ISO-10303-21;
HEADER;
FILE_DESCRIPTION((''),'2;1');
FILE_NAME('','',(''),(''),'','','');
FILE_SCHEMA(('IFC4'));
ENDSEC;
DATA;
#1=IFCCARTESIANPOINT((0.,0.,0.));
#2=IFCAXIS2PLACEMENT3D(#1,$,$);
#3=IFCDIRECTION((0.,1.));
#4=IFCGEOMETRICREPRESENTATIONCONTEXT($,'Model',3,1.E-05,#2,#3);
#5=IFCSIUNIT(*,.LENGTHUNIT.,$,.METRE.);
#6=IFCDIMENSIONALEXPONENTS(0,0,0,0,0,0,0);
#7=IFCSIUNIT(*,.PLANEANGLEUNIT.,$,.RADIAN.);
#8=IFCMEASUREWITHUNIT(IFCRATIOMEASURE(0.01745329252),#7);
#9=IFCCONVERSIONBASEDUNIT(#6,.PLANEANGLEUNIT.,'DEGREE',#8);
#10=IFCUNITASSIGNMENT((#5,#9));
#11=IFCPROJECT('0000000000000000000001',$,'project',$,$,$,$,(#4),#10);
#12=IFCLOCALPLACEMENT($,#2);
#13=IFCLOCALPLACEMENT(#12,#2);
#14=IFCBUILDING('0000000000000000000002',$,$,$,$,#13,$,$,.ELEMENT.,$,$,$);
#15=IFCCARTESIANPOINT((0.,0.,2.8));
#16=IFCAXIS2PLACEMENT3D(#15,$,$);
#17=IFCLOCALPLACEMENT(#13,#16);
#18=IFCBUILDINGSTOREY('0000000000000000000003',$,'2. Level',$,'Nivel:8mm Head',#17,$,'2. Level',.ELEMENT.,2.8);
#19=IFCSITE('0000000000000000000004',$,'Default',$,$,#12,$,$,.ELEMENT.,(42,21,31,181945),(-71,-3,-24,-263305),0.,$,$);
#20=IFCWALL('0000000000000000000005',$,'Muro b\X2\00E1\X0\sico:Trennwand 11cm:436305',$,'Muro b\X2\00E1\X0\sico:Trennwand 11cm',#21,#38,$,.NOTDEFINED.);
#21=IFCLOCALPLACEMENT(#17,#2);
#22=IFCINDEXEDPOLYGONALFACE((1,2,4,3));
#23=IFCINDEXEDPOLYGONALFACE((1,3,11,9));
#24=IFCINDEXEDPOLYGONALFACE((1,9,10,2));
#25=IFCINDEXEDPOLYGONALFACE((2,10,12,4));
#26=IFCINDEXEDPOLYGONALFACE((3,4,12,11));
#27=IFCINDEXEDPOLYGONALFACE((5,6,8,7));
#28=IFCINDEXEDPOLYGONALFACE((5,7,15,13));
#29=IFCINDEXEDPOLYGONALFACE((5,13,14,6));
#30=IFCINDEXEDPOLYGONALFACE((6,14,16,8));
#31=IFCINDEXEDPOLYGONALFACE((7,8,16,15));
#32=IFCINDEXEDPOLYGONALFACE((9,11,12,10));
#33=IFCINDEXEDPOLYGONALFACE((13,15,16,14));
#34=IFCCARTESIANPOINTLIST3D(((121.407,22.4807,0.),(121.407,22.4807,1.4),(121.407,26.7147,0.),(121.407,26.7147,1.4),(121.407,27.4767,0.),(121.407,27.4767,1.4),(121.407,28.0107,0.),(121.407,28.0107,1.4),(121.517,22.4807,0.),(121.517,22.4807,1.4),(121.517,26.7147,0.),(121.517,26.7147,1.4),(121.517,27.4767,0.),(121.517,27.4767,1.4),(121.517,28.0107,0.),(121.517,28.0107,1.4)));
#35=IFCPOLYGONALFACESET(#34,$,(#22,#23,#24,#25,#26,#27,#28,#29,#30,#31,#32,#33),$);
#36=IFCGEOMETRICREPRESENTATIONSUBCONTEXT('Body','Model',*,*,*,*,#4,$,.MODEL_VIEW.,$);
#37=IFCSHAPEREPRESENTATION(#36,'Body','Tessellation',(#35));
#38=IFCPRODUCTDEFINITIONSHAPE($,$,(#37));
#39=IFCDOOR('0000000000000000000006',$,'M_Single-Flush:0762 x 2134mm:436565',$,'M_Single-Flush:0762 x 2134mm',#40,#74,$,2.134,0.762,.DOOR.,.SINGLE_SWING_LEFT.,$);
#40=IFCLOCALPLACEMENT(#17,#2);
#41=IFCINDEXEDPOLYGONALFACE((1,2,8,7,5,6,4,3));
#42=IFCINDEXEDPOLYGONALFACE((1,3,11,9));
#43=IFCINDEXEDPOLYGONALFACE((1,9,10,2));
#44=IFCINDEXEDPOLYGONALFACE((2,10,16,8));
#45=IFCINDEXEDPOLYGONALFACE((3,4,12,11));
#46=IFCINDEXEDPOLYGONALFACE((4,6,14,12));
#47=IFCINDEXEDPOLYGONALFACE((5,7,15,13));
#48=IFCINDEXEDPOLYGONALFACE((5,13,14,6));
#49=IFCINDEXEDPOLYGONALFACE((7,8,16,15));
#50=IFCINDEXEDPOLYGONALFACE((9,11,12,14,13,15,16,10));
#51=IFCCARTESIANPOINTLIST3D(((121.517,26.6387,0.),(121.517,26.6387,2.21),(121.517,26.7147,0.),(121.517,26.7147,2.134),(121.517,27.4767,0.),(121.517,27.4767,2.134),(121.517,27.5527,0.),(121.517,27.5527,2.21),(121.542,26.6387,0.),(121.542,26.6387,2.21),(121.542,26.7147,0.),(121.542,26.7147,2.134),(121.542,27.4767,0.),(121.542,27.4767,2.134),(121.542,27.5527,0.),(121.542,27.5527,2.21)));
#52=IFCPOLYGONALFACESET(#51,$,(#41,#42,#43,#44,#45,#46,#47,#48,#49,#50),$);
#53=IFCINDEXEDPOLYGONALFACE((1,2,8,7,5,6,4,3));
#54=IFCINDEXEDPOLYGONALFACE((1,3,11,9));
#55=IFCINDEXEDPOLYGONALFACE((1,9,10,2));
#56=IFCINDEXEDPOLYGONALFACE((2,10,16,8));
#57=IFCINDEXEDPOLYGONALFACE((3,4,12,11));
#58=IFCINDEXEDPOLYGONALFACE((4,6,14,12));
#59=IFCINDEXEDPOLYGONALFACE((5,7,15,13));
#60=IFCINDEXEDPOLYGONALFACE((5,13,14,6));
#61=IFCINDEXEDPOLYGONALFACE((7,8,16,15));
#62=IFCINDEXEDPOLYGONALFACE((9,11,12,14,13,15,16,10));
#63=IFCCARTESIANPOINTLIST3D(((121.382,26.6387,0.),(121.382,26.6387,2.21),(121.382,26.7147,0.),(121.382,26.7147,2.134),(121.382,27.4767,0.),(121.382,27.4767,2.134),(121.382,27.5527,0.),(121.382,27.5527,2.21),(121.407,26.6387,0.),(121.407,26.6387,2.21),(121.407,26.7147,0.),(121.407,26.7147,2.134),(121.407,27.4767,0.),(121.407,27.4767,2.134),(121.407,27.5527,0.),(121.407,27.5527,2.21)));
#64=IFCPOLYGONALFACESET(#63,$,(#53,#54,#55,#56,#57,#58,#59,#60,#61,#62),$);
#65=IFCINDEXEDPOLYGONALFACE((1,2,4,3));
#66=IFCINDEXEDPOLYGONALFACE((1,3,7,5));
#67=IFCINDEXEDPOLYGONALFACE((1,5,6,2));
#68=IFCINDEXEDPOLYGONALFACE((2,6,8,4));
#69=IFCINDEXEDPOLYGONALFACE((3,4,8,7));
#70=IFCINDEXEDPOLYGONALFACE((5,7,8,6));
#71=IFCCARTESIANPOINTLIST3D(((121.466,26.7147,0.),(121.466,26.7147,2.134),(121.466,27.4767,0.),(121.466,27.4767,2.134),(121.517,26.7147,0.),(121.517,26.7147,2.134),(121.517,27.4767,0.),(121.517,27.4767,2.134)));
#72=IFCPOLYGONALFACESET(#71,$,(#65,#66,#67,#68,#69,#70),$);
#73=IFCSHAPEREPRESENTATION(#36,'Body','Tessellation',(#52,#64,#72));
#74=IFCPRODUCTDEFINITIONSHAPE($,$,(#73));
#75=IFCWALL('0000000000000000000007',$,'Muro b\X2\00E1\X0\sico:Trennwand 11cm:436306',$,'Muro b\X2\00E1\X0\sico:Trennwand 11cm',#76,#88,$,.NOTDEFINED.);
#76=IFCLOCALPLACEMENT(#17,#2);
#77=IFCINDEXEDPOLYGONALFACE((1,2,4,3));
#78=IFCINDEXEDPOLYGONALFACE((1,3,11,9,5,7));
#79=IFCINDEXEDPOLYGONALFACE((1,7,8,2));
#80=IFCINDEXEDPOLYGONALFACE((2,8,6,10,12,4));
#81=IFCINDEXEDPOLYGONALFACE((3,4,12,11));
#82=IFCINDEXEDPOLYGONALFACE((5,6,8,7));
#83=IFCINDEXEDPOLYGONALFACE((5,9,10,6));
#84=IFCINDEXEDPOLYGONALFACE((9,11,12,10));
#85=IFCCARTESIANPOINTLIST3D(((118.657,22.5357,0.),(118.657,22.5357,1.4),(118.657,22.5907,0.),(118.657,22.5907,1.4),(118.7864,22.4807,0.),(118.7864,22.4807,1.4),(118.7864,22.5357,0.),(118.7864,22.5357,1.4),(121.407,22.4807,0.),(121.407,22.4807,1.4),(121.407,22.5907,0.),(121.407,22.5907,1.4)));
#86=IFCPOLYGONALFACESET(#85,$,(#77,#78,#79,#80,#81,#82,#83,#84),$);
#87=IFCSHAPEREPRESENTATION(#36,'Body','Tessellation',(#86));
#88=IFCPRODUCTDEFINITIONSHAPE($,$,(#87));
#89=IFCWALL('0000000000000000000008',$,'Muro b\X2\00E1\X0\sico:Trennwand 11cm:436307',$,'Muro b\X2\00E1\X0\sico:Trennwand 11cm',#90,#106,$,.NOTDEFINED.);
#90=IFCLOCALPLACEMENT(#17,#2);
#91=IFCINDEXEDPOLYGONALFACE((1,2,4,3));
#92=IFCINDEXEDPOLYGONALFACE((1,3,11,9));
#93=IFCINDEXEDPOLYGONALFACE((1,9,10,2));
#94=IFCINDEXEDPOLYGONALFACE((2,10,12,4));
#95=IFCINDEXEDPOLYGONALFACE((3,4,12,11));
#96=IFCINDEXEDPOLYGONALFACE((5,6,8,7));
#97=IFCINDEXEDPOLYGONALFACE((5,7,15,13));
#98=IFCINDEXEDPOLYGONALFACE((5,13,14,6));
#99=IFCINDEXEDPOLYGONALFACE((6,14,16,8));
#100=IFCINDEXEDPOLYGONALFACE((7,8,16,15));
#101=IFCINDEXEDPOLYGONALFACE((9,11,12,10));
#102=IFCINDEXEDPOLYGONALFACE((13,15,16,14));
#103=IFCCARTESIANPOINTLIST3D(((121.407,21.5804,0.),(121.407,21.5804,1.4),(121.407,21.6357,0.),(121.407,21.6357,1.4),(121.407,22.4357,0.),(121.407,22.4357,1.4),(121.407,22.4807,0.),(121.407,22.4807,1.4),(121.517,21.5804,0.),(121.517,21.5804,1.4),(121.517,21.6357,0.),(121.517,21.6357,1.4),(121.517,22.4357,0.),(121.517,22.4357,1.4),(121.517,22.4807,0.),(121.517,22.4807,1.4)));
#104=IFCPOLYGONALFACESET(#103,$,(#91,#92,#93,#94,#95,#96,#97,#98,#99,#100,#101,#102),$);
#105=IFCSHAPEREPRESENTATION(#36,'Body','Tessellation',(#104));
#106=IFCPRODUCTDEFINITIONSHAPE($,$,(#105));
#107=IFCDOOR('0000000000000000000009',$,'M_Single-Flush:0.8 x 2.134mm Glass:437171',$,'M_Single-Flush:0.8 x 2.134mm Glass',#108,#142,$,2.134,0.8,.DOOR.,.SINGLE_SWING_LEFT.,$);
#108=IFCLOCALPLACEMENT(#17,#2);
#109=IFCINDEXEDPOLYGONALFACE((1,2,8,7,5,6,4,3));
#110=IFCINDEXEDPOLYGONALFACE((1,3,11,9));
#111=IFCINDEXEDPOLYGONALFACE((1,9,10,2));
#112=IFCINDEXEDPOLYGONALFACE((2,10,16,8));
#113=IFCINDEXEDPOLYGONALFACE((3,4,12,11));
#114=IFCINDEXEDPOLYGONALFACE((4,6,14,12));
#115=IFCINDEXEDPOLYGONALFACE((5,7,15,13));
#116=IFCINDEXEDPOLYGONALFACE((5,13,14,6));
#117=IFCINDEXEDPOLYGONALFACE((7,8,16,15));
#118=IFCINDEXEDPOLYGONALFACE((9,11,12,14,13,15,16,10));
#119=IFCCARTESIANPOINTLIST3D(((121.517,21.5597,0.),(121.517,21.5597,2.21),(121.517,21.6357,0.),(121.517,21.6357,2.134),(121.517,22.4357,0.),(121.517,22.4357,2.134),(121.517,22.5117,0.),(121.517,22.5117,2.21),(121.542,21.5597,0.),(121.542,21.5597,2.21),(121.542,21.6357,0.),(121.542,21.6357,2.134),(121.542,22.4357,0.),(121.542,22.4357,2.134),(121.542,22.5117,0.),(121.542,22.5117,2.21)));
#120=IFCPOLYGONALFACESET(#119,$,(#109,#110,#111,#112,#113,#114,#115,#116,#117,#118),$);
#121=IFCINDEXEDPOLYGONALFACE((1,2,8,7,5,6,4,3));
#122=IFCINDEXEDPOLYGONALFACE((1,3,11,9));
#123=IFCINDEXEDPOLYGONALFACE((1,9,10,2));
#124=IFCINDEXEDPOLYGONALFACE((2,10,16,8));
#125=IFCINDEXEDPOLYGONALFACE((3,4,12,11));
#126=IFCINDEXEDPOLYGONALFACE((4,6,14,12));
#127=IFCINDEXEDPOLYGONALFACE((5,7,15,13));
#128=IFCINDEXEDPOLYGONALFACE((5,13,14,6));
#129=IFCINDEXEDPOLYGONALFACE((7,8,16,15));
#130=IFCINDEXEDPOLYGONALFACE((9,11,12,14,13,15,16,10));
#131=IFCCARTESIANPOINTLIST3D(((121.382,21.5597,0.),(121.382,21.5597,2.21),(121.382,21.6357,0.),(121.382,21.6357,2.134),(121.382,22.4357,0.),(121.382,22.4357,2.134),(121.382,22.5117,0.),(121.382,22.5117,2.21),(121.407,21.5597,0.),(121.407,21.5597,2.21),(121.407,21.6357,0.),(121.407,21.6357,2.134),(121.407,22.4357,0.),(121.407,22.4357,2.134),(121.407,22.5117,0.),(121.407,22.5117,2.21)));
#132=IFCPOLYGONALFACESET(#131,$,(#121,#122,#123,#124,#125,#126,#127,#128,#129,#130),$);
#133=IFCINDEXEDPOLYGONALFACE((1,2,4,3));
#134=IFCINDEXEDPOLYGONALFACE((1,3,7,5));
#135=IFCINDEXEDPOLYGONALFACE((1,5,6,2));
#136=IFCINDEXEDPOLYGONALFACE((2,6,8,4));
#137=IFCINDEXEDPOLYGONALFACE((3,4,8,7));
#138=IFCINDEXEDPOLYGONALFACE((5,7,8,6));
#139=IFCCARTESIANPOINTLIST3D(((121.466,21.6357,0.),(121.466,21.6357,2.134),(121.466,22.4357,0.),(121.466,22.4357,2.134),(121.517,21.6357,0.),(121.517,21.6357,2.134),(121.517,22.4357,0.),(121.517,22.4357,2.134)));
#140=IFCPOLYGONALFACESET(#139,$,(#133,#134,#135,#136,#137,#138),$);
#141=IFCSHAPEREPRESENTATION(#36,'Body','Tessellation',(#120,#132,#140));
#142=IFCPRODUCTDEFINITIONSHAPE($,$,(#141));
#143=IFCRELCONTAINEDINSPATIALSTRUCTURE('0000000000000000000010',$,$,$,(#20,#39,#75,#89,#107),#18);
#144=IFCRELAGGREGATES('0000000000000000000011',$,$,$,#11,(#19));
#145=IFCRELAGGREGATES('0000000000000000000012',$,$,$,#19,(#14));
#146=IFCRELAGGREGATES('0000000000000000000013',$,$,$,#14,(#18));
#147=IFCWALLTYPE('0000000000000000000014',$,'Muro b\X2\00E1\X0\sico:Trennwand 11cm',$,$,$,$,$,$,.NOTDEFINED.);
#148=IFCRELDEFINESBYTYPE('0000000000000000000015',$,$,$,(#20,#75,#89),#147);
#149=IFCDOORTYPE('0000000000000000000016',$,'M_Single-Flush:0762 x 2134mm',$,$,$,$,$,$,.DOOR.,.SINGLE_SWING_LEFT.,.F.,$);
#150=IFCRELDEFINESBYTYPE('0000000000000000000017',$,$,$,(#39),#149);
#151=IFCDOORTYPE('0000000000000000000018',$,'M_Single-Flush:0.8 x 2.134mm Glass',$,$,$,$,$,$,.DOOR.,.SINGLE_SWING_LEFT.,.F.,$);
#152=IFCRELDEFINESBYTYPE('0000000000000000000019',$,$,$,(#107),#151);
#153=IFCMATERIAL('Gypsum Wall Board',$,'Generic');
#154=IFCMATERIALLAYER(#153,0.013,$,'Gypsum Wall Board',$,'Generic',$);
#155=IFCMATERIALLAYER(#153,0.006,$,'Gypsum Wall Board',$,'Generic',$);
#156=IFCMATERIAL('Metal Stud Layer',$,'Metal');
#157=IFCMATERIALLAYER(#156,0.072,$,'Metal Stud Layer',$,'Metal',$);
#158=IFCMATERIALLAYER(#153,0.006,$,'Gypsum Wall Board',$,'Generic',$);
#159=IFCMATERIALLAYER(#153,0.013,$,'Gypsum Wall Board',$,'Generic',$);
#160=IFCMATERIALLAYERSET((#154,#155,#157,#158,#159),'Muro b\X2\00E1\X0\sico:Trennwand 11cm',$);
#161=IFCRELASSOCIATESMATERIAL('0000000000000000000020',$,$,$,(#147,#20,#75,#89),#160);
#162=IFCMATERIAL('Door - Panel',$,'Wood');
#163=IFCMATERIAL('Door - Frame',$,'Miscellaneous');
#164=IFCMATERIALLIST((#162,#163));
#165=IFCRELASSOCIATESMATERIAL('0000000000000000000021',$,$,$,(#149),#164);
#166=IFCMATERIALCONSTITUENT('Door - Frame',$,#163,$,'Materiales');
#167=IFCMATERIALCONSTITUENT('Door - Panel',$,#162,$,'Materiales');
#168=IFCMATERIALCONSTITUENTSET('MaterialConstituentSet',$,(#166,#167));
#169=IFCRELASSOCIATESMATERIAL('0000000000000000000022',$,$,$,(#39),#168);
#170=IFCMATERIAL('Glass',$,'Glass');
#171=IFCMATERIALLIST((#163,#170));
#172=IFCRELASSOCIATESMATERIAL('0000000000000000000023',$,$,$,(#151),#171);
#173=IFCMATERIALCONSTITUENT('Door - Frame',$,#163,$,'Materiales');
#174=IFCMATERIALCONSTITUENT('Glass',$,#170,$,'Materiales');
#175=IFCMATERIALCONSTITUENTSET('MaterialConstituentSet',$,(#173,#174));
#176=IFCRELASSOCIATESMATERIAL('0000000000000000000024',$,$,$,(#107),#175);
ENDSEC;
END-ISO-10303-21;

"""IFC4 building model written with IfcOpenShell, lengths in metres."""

from ifc_helpers import new_model, entity, si_unit, converted_unit, direction, frame, frame_2d, origin, origin_2d_with_axis, place, context, subcontext, project, spatial, polyline, rectangle, outline, extrude, clip, halfspace, source, transform, mapped, material, material_list, layer, layer_set, layer_usage, constituent, constituent_set, type_object, type_shapes, element, fill, save


model = new_model("IFC4")

# Units and contexts
model_context = context("Model", 3, precision=1e-05, world=origin(), true_north=direction((0.0, 1.0)))
body_context = subcontext(model_context, "Body", "Model", "MODEL_VIEW")
ifc_project = project(units=[si_unit("LENGTHUNIT", "METRE"), converted_unit("PLANEANGLEUNIT", "DEGREE", entity("IfcRatioMeasure", 0.01745329252), si_unit("PLANEANGLEUNIT", "RADIAN"), dimensions=[0, 0, 0, 0, 0, 0, 0])], contexts=[model_context])

# Site, building, storey
site_placement = place(None, origin())
site = spatial("IfcSite", under=ifc_project, at=site_placement, Name="Default", CompositionType="ELEMENT", RefLatitude=(42, 21, 31, 181945), RefLongitude=(-71, -3, -24, -263305), RefElevation=0.0)
building_placement = place(site_placement, origin())
building = spatial("IfcBuilding", under=site, at=building_placement, CompositionType="ELEMENT")
storey_placement = place(building_placement, frame((0.0, 0.0, 2.8)))
storey = spatial("IfcBuildingStorey", under=building, at=storey_placement, Name="2. Level", ObjectType="Nivel:8mm Head", LongName="2. Level", CompositionType="ELEMENT", Elevation=2.8)

# Shared definitions
ifc_material_1 = material(Name="Glass", Category="Glass")

# Wall, opening, door
ifc_material_2 = material(Name="Gypsum Wall Board", Category="Generic")
ifc_layer_1 = layer(ifc_material_2, 0.013, Name="Gypsum Wall Board", Category="Generic")
ifc_layer_2 = layer(ifc_material_2, 0.006, Name="Gypsum Wall Board", Category="Generic")
ifc_material_3 = material(Name="Metal Stud Layer", Category="Metal")
ifc_layer_3 = layer(ifc_material_3, 0.072, Name="Metal Stud Layer", Category="Metal")
ifc_layer_4 = layer(ifc_material_2, 0.006, Name="Gypsum Wall Board", Category="Generic")
ifc_layer_5 = layer(ifc_material_2, 0.013, Name="Gypsum Wall Board", Category="Generic")
ifc_layer_set_1 = layer_set([ifc_layer_1, ifc_layer_2, ifc_layer_3, ifc_layer_4, ifc_layer_5], Name="Muro básico:Trennwand 11cm")
ifc_layer_usage_1 = layer_usage(ifc_layer_set_1, "AXIS2", "NEGATIVE", 0.055)
wall_type_1 = type_object("IfcWallType", Name="Muro básico:Trennwand 11cm", PredefinedType="NOTDEFINED", material=ifc_layer_set_1)
wall_1_placement = place(storey_placement, frame((121.462, 28.0107, 0.0), z_axis=(0.0, 0.0, 1.0), x_axis=(0.0, -1.0, 0.0)))
wall_1 = element("IfcWall", 1, at=wall_1_placement, inside=storey, type_object=wall_type_1, material=ifc_layer_usage_1, Name="Muro básico:Trennwand 11cm:436305", ObjectType="Muro básico:Trennwand 11cm", PredefinedType="NOTDEFINED", context=body_context, shape_type="Clipping", body=[
    clip(extrude(rectangle(XDim=5.53, YDim=0.11, at=frame_2d((2.765, 0.0), x_axis=(-1.0, 0.0))), origin(), (0.0, 0.0, 1.0), 1.4), halfspace(origin(), True)),
])
opening_1_placement = place(wall_1_placement, frame((0.534, -0.055, 0.0)))
opening_1 = element("IfcOpeningElement", 2, at=opening_1_placement, cuts=wall_1, ObjectType="Opening", PredefinedType="OPENING", context=body_context, shape_type="SweptSolid", body=[
    extrude(rectangle(XDim=0.762, YDim=2.134, at=frame_2d((1.067, 0.381), x_axis=(0.0, -1.0))), frame((0.0, 0.0, 0.0), z_axis=(0.0, 1.0, 0.0), x_axis=(0.0, 0.0, 1.0)), (0.0, 0.0, 1.0), 0.11),
])
ifc_material_4 = material(Name="Door - Frame", Category="Miscellaneous")
ifc_constituent_1 = constituent(ifc_material_4, Name="Door - Frame", Category="Materiales")
ifc_material_5 = material(Name="Door - Panel", Category="Wood")
ifc_constituent_2 = constituent(ifc_material_5, Name="Door - Panel", Category="Materiales")
ifc_constituent_set_1 = constituent_set(constituents=[ifc_constituent_1, ifc_constituent_2], Name="MaterialConstituentSet")
ifc_material_list_1 = material_list([ifc_material_5, ifc_material_4])
door_type_1 = type_object("IfcDoorType", Name="M_Single-Flush:0762 x 2134mm", OperationType="SINGLE_SWING_LEFT", ParameterTakesPrecedence=False, PredefinedType="DOOR", material=ifc_material_list_1)
shared_shape_1 = source(origin(), body_context, "Body", "SweptSolid", [
    extrude(outline(polyline([(-0.457, -1.124), (0.457, -1.124), (0.457, 1.086), (0.381, 1.086), (0.381, -1.048), (-0.381, -1.048), (-0.381, 1.086), (-0.457, 1.086), (-0.457, -1.124)])), frame((0.381, 0.135, 1.086), z_axis=(0.0, -1.0, 0.0), x_axis=(-1.0, 0.0, 0.0)), (0.0, 0.0, 1.0), 0.025),
    extrude(outline(polyline([(-1.124, -0.457), (1.086, -0.457), (1.086, -0.381), (-1.048, -0.381), (-1.048, 0.381), (1.086, 0.381), (1.086, 0.457), (-1.124, 0.457), (-1.124, -0.457)])), frame((0.381, 0.0, 1.086), z_axis=(0.0, -1.0, 0.0), x_axis=(0.0, 0.0, -1.0)), (0.0, 0.0, 1.0), 0.025),
    extrude(rectangle(XDim=0.762, YDim=0.051, at=origin_2d_with_axis()), frame((0.381, 0.0845, 0.0)), (0.0, 0.0, 1.0), 2.134),
])
type_shapes(door_type_1, [shared_shape_1])
door_1_placement = place(opening_1_placement, origin())
door_1 = element("IfcDoor", 3, at=door_1_placement, inside=storey, type_object=door_type_1, material=ifc_constituent_set_1, Name="M_Single-Flush:0762 x 2134mm:436565", ObjectType="M_Single-Flush:0762 x 2134mm", OperationType="SINGLE_SWING_LEFT", OverallHeight=2.134, OverallWidth=0.762, PredefinedType="DOOR", context=body_context, shape_type="MappedRepresentation", body=[
    mapped(shared_shape_1, transform((0.0, 0.0, 0.0), scale=1.0)),
])
fill(opening_1, door_1)

# Wall
ifc_layer_usage_2 = layer_usage(ifc_layer_set_1, "AXIS2", "NEGATIVE", 0.055)
wall_2_placement = place(storey_placement, frame((121.407, 22.5357, 0.0), z_axis=(0.0, 0.0, 1.0), x_axis=(-1.0, 0.0, 0.0)))
element("IfcWall", 4, at=wall_2_placement, inside=storey, type_object=wall_type_1, material=ifc_layer_usage_2, Name="Muro básico:Trennwand 11cm:436306", ObjectType="Muro básico:Trennwand 11cm", PredefinedType="NOTDEFINED", context=body_context, shape_type="Clipping", body=[
    clip(extrude(outline(polyline([(2.75, -0.055), (2.75, 0.0), (2.6206, 0.0), (2.6206, 0.055), (0.0, 0.055), (0.0, -0.055), (2.75, -0.055)])), origin(), (0.0, 0.0, 1.0), 1.4), halfspace(origin(), True)),
])

# Wall, opening, door
ifc_layer_usage_3 = layer_usage(ifc_layer_set_1, "AXIS2", "NEGATIVE", 0.055)
wall_3_placement = place(storey_placement, frame((121.462, 21.5804, 0.0), z_axis=(0.0, 0.0, 1.0), x_axis=(0.0, 1.0, 0.0)))
wall_3 = element("IfcWall", 5, at=wall_3_placement, inside=storey, type_object=wall_type_1, material=ifc_layer_usage_3, Name="Muro básico:Trennwand 11cm:436307", ObjectType="Muro básico:Trennwand 11cm", PredefinedType="NOTDEFINED", context=body_context, shape_type="Clipping", body=[
    clip(extrude(rectangle(XDim=0.9003, YDim=0.11, at=frame_2d((0.4502, 0.0), x_axis=(-1.0, 0.0))), origin(), (0.0, 0.0, 1.0), 1.4), halfspace(origin(), True)),
])
opening_2_placement = place(wall_3_placement, frame((0.8553, 0.055, 0.0)))
opening_2 = element("IfcOpeningElement", 6, at=opening_2_placement, cuts=wall_3, ObjectType="Opening", PredefinedType="OPENING", context=body_context, shape_type="SweptSolid", body=[
    extrude(rectangle(XDim=0.8, YDim=2.134, at=frame_2d((1.067, 0.4), x_axis=(0.0, -1.0))), frame((0.0, 0.0, 0.0), z_axis=(0.0, -1.0, 0.0), x_axis=(0.0, 0.0, 1.0)), (0.0, 0.0, 1.0), 0.11),
])
ifc_constituent_3 = constituent(ifc_material_4, Name="Door - Frame", Category="Materiales")
ifc_constituent_4 = constituent(ifc_material_1, Name="Glass", Category="Materiales")
ifc_constituent_set_2 = constituent_set(constituents=[ifc_constituent_3, ifc_constituent_4], Name="MaterialConstituentSet")
ifc_material_list_2 = material_list([ifc_material_4, ifc_material_1])
door_type_2 = type_object("IfcDoorType", Name="M_Single-Flush:0.8 x 2.134mm Glass", OperationType="SINGLE_SWING_LEFT", ParameterTakesPrecedence=False, PredefinedType="DOOR", material=ifc_material_list_2)
shared_shape_2 = source(origin(), body_context, "Body", "SweptSolid", [
    extrude(outline(polyline([(-0.476, -1.124), (0.476, -1.124), (0.476, 1.086), (0.4, 1.086), (0.4, -1.048), (-0.4, -1.048), (-0.4, 1.086), (-0.476, 1.086), (-0.476, -1.124)])), frame((0.4, 0.135, 1.086), z_axis=(0.0, -1.0, 0.0), x_axis=(-1.0, 0.0, 0.0)), (0.0, 0.0, 1.0), 0.025),
    extrude(outline(polyline([(-1.124, -0.476), (1.086, -0.476), (1.086, -0.4), (-1.048, -0.4), (-1.048, 0.4), (1.086, 0.4), (1.086, 0.476), (-1.124, 0.476), (-1.124, -0.476)])), frame((0.4, 0.0, 1.086), z_axis=(0.0, -1.0, 0.0), x_axis=(0.0, 0.0, -1.0)), (0.0, 0.0, 1.0), 0.025),
    extrude(rectangle(XDim=0.8, YDim=0.051, at=origin_2d_with_axis()), frame((0.4, 0.0845, 0.0)), (0.0, 0.0, 1.0), 2.134),
])
type_shapes(door_type_2, [shared_shape_2])
door_2_placement = place(opening_2_placement, frame((0.0, 0.0, 0.0), z_axis=(0.0, 0.0, 1.0), x_axis=(-1.0, 0.0, 0.0)))
door_2 = element("IfcDoor", 7, at=door_2_placement, inside=storey, type_object=door_type_2, material=ifc_constituent_set_2, Name="M_Single-Flush:0.8 x 2.134mm Glass:437171", ObjectType="M_Single-Flush:0.8 x 2.134mm Glass", OperationType="SINGLE_SWING_LEFT", OverallHeight=2.134, OverallWidth=0.8, PredefinedType="DOOR", context=body_context, shape_type="MappedRepresentation", body=[
    mapped(shared_shape_2, transform((0.0, 0.0, 0.0), scale=1.0)),
])
fill(opening_2, door_2)

save(model, "model.ifc")
